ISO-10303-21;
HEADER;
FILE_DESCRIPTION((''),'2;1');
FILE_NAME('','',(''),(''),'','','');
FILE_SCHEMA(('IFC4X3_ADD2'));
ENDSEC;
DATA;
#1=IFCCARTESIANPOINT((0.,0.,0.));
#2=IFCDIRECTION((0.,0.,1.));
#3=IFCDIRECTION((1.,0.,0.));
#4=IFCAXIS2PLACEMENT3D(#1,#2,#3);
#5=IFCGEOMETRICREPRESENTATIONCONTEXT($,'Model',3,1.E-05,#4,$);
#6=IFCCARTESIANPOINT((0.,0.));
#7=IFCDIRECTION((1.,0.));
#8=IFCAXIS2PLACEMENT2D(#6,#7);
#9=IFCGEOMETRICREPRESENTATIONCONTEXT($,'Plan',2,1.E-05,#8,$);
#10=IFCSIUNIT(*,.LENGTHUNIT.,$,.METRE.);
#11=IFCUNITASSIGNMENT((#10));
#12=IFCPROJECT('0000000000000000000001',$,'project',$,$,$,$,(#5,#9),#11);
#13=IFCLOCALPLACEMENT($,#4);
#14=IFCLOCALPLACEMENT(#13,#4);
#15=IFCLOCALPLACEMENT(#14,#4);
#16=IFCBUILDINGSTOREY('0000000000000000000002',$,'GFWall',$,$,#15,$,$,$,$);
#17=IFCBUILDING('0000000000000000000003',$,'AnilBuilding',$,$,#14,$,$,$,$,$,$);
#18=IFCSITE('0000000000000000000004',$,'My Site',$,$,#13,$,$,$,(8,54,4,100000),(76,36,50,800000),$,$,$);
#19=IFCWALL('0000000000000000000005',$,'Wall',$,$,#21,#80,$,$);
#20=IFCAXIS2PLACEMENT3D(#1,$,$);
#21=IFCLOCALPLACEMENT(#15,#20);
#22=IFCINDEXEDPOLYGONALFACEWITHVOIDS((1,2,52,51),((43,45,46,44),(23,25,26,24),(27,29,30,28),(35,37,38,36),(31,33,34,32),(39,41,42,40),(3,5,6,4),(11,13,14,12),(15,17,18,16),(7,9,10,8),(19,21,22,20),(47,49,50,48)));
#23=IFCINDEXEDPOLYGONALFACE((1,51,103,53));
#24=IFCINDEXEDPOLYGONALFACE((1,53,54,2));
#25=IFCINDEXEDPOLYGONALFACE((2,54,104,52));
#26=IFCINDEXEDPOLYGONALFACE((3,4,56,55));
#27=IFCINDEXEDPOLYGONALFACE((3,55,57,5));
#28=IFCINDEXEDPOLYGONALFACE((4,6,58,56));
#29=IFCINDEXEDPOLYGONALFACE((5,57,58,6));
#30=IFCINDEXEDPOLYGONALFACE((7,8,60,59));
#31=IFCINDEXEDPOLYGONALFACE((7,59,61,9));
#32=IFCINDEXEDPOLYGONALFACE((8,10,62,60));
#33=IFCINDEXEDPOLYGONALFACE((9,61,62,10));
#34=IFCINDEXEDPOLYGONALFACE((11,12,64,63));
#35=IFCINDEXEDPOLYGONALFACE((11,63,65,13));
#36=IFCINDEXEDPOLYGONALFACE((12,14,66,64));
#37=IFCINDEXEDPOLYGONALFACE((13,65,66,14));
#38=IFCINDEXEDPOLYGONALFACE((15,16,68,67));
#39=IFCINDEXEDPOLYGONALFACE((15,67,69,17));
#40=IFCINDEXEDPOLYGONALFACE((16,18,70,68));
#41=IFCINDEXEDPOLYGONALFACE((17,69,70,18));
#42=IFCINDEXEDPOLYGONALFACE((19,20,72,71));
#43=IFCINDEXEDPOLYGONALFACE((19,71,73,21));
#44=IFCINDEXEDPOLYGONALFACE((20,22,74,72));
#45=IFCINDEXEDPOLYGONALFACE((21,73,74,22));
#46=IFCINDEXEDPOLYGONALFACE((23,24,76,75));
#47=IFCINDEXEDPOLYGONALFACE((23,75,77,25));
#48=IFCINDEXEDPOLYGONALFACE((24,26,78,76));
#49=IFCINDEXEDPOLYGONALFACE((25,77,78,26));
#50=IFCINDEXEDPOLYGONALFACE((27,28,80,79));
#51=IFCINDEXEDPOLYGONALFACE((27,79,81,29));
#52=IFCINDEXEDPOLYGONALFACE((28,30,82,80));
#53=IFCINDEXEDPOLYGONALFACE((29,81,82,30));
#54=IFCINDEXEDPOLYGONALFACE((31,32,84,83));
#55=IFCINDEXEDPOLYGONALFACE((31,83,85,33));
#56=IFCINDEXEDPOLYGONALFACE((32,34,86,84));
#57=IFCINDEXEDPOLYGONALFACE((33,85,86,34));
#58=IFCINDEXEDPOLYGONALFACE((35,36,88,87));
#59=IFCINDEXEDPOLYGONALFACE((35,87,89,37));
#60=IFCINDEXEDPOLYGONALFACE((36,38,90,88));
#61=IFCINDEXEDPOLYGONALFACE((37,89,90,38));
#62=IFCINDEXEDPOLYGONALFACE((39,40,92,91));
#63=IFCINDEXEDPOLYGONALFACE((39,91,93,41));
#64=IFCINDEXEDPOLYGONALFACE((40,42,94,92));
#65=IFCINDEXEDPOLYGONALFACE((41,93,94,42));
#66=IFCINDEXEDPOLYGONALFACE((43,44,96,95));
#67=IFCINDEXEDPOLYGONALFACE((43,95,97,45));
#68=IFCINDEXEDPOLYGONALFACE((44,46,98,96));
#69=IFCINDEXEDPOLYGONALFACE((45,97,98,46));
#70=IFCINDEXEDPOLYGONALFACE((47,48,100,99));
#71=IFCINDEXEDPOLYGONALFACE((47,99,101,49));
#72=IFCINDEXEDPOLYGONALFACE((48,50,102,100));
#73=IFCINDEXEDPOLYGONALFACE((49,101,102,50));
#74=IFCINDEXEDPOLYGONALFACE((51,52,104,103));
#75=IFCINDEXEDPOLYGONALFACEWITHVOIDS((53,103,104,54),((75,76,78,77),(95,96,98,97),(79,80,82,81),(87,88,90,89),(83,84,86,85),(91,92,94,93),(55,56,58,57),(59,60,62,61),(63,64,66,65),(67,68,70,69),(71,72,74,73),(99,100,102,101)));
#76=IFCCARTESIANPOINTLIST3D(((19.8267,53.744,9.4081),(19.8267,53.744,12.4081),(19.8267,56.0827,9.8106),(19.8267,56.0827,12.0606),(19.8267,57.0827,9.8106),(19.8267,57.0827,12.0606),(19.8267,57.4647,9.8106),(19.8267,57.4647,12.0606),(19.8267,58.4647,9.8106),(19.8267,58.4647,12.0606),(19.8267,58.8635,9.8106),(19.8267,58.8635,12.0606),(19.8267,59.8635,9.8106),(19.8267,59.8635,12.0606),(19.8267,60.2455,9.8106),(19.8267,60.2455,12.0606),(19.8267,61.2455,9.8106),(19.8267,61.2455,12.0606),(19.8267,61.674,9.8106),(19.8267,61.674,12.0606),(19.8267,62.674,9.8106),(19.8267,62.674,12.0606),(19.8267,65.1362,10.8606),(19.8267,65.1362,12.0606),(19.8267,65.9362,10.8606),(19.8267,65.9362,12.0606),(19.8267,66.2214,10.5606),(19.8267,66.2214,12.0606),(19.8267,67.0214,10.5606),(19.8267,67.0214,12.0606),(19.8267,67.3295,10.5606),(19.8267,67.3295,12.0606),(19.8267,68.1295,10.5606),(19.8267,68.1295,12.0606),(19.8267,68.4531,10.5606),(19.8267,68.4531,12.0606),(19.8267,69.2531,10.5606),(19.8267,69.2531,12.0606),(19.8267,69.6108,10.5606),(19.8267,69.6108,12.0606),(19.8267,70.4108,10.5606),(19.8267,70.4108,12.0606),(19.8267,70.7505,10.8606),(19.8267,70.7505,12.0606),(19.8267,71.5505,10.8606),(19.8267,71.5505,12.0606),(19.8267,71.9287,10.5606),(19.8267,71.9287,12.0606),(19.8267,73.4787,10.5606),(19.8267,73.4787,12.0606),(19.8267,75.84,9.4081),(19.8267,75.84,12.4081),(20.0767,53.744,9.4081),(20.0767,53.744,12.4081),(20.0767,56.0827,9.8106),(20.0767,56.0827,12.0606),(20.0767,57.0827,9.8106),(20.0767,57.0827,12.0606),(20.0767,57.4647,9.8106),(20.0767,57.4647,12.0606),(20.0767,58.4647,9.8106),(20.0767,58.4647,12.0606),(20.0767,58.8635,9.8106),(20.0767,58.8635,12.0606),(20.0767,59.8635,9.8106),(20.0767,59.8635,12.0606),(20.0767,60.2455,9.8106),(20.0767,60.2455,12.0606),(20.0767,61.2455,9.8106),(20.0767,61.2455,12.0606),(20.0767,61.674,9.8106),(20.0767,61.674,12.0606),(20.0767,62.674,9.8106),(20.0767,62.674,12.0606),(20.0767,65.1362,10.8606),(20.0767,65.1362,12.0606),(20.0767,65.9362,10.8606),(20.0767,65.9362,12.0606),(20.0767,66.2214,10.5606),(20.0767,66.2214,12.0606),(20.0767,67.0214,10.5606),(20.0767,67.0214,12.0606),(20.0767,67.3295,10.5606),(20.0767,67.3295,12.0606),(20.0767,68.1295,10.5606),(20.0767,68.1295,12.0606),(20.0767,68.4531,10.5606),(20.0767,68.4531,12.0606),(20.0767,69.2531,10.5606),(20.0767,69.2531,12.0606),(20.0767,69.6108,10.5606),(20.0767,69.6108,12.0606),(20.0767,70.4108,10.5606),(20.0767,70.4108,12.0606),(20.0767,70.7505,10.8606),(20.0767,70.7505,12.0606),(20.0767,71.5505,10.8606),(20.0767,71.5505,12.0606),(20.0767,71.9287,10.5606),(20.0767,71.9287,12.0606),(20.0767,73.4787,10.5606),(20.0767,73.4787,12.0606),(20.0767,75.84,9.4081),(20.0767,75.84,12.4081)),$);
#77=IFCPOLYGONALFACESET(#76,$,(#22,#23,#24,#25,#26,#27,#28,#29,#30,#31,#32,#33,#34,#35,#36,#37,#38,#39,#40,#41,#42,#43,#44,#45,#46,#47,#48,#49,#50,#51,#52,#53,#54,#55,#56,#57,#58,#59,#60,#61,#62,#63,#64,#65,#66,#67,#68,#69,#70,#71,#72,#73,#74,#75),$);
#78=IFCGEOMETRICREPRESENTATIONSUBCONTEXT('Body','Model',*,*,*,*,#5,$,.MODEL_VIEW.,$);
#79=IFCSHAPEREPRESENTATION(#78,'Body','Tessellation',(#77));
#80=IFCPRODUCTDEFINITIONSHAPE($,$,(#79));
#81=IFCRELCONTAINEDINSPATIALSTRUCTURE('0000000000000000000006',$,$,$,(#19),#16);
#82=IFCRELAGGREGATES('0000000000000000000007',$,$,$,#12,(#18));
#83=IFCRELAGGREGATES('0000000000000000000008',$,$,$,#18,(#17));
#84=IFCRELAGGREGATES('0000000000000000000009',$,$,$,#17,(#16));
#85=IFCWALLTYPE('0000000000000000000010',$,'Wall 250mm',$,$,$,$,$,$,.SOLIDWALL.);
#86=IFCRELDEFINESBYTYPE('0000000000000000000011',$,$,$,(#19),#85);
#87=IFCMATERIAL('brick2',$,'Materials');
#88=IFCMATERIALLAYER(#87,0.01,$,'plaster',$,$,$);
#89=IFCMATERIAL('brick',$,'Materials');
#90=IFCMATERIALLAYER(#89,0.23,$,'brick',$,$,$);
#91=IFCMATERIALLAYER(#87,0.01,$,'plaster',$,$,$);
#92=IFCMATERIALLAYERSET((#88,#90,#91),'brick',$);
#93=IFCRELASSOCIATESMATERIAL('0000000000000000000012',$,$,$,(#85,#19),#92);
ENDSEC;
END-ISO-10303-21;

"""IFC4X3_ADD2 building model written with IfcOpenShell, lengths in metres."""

from ifc_helpers import new_model, si_unit, frame, origin_with_axes, origin_2d_with_axis, place, context, subcontext, project, spatial, line, indexed_curve, outline, extrude, source, transform, mapped, material, layer, layer_set, layer_usage, type_object, element, save


model = new_model("IFC4X3_ADD2")

# Units and contexts
model_context = context("Model", 3, precision=1e-05, world=origin_with_axes())
plan_context = context("Plan", 2, precision=1e-05, world=origin_2d_with_axis())
body_context = subcontext(model_context, "Body", "Model", "MODEL_VIEW")
ifc_project = project(units=[si_unit("LENGTHUNIT", "METRE")], contexts=[model_context, plan_context])

# Site, building, storey
site_placement = place(None, origin_with_axes())
site = spatial("IfcSite", under=ifc_project, at=site_placement, Name="My Site", RefLatitude=(8, 54, 4, 100000), RefLongitude=(76, 36, 50, 800000))
building_placement = place(site_placement, origin_with_axes())
building = spatial("IfcBuilding", under=site, at=building_placement, Name="AnilBuilding")
storey_placement = place(building_placement, origin_with_axes())
storey = spatial("IfcBuildingStorey", under=building, at=storey_placement, Name="GFWall")

# Wall, openings
ifc_material_1 = material(Name="brick2", Category="Materials")
ifc_layer_1 = layer(ifc_material_1, 0.01, Name="plaster")
ifc_material_2 = material(Name="brick", Category="Materials")
ifc_layer_2 = layer(ifc_material_2, 0.23, Name="brick")
ifc_layer_3 = layer(ifc_material_1, 0.01, Name="plaster")
ifc_layer_set = layer_set([ifc_layer_1, ifc_layer_2, ifc_layer_3], Name="brick")
ifc_layer_usage = layer_usage(ifc_layer_set, "AXIS2", "POSITIVE", 0.0)
wall_type = type_object("IfcWallType", Name="Wall 250mm", PredefinedType="SOLIDWALL", material=ifc_layer_set)
wall_placement = place(storey_placement, frame((20.0767, 53.744, 9.4081), z_axis=(0.0, 0.0, 1.0), x_axis=(0.0, 1.0, 0.0)))
wall = element("IfcWall", 1, at=wall_placement, inside=storey, type_object=wall_type, material=ifc_layer_usage, Name="Wall", context=body_context, shape_type="SweptSolid", body=[
    extrude(outline(indexed_curve([(0.0, 0.0), (0.0, 0.25), (22.096, 0.25), (22.096, 0.0)], segments=[line(1, 2, 3, 4, 1)])), origin_with_axes(), (0.0, 0.0, 1.0), 3.0),
])
shared_shape_1 = source(origin_with_axes(), body_context, "Body", "SweptSolid", [
    extrude(outline(indexed_curve([(0.0, 0.0), (1.0, 0.0), (1.0, 2.25), (0.0, 2.25)], segments=[line(1, 2, 3, 4, 1)])), frame((0.0, -0.6, 0.0), z_axis=(0.0, -1.0, 0.0), x_axis=(1.0, 0.0, 0.0)), (0.0, 0.0, -1.0), 1.2),
])
opening_1_placement = place(wall_placement, frame((2.3387, 0.0, 0.4025), z_axis=(0.0, 0.0, 1.0), x_axis=(1.0, 0.0, 0.0)))
element("IfcOpeningElement", 2, at=opening_1_placement, cuts=wall, PredefinedType="OPENING", context=body_context, shape_type="MappedRepresentation", body=[
    mapped(shared_shape_1, transform((0.0, 0.0, 0.0), x_axis=(1.0, 0.0, 0.0), y_axis=(0.0, 1.0, 0.0), z_axis=(0.0, 0.0, 1.0), scale=1.0)),
])
opening_2_placement = place(wall_placement, frame((3.7207, 0.0, 0.4025), z_axis=(0.0, 0.0, 1.0), x_axis=(1.0, 0.0, 0.0)))
element("IfcOpeningElement", 3, at=opening_2_placement, cuts=wall, PredefinedType="OPENING", context=body_context, shape_type="MappedRepresentation", body=[
    mapped(shared_shape_1, transform((0.0, 0.0, 0.0), x_axis=(1.0, 0.0, 0.0), y_axis=(0.0, 1.0, 0.0), z_axis=(0.0, 0.0, 1.0), scale=1.0)),
])
opening_3_placement = place(wall_placement, frame((5.1195, 0.0, 0.4025), z_axis=(0.0, 0.0, 1.0), x_axis=(1.0, 0.0, 0.0)))
element("IfcOpeningElement", 4, at=opening_3_placement, cuts=wall, PredefinedType="OPENING", context=body_context, shape_type="MappedRepresentation", body=[
    mapped(shared_shape_1, transform((0.0, 0.0, 0.0), x_axis=(1.0, 0.0, 0.0), y_axis=(0.0, 1.0, 0.0), z_axis=(0.0, 0.0, 1.0), scale=1.0)),
])
opening_4_placement = place(wall_placement, frame((6.5014, 0.0, 0.4025), z_axis=(0.0, 0.0, 1.0), x_axis=(1.0, 0.0, 0.0)))
element("IfcOpeningElement", 5, at=opening_4_placement, cuts=wall, PredefinedType="OPENING", context=body_context, shape_type="MappedRepresentation", body=[
    mapped(shared_shape_1, transform((0.0, 0.0, 0.0), x_axis=(1.0, 0.0, 0.0), y_axis=(0.0, 1.0, 0.0), z_axis=(0.0, 0.0, 1.0), scale=1.0)),
])
opening_5_placement = place(wall_placement, frame((7.93, 0.0, 0.4025), z_axis=(0.0, 0.0, 1.0), x_axis=(1.0, 0.0, 0.0)))
element("IfcOpeningElement", 6, at=opening_5_placement, cuts=wall, PredefinedType="OPENING", context=body_context, shape_type="MappedRepresentation", body=[
    mapped(shared_shape_1, transform((0.0, 0.0, 0.0), x_axis=(1.0, 0.0, 0.0), y_axis=(0.0, 1.0, 0.0), z_axis=(0.0, 0.0, 1.0), scale=1.0)),
])
shared_shape_2 = source(origin_with_axes(), body_context, "Body", "SweptSolid", [
    extrude(outline(indexed_curve([(0.0, 0.0), (1.55, 0.0), (1.55, 1.5), (0.0, 1.5)], segments=[line(1, 2, 3, 4, 1)])), frame((0.0, -0.6, 0.0), z_axis=(0.0, -1.0, 0.0), x_axis=(1.0, 0.0, 0.0)), (0.0, 0.0, -1.0), 1.2),
])
opening_6_placement = place(wall_placement, frame((18.1847, 0.0, 1.1525), z_axis=(0.0, 0.0, 1.0), x_axis=(1.0, 0.0, 0.0)))
element("IfcOpeningElement", 7, at=opening_6_placement, cuts=wall, PredefinedType="OPENING", context=body_context, shape_type="MappedRepresentation", body=[
    mapped(shared_shape_2, transform((0.0, 0.0, 0.0), x_axis=(1.0, 0.0, 0.0), y_axis=(0.0, 1.0, 0.0), z_axis=(0.0, 0.0, 1.0), scale=1.0)),
])
shared_shape_3 = source(origin_with_axes(), body_context, "Body", "SweptSolid", [
    extrude(outline(indexed_curve([(0.0, 0.0), (0.8, 0.0), (0.8, 1.2), (0.0, 1.2)], segments=[line(1, 2, 3, 4, 1)])), frame((0.0, -0.6, 0.0), z_axis=(0.0, -1.0, 0.0), x_axis=(1.0, 0.0, 0.0)), (0.0, 0.0, -1.0), 1.2),
])
opening_7_placement = place(wall_placement, frame((11.3922, 0.0, 1.4525), z_axis=(0.0, 0.0, 1.0), x_axis=(1.0, 0.0, 0.0)))
element("IfcOpeningElement", 8, at=opening_7_placement, cuts=wall, PredefinedType="OPENING", context=body_context, shape_type="MappedRepresentation", body=[
    mapped(shared_shape_3, transform((0.0, 0.0, 0.0), x_axis=(1.0, 0.0, 0.0), y_axis=(0.0, 1.0, 0.0), z_axis=(0.0, 0.0, 1.0), scale=1.0)),
])
shared_shape_4 = source(origin_with_axes(), body_context, "Body", "SweptSolid", [
    extrude(outline(indexed_curve([(0.0, 0.0), (0.8, 0.0), (0.8, 1.5), (0.0, 1.5)], segments=[line(1, 2, 3, 4, 1)])), frame((0.0, -0.6, 0.0), z_axis=(0.0, -1.0, 0.0), x_axis=(1.0, 0.0, 0.0)), (0.0, 0.0, -1.0), 1.2),
])
opening_8_placement = place(wall_placement, frame((12.4774, 0.0, 1.1525), z_axis=(0.0, 0.0, 1.0), x_axis=(1.0, 0.0, 0.0)))
element("IfcOpeningElement", 9, at=opening_8_placement, cuts=wall, PredefinedType="OPENING", context=body_context, shape_type="MappedRepresentation", body=[
    mapped(shared_shape_4, transform((0.0, 0.0, 0.0), x_axis=(1.0, 0.0, 0.0), y_axis=(0.0, 1.0, 0.0), z_axis=(0.0, 0.0, 1.0), scale=1.0)),
])
shared_shape_5 = source(origin_with_axes(), body_context, "Body", "SweptSolid", [
    extrude(outline(indexed_curve([(0.0, 1.5), (0.8, 1.5), (0.8, 0.0), (0.0, 0.0), (0.0, 1.5)])), frame((0.0, -0.6, 0.0), z_axis=(0.0, -1.0, 0.0), x_axis=(1.0, 0.0, 0.0)), (0.0, 0.0, -1.0), 1.2),
])
opening_9_placement = place(wall_placement, frame((13.5855, 0.0, 1.1525), z_axis=(0.0, 0.0, 1.0), x_axis=(1.0, 0.0, 0.0)))
element("IfcOpeningElement", 10, at=opening_9_placement, cuts=wall, PredefinedType="OPENING", context=body_context, shape_type="MappedRepresentation", body=[
    mapped(shared_shape_5, transform((0.0, 0.0, 0.0), x_axis=(1.0, 0.0, 0.0), y_axis=(0.0, 1.0, 0.0), z_axis=(0.0, 0.0, 1.0), scale=1.0)),
])
opening_10_placement = place(wall_placement, frame((14.7091, 0.0, 1.1525), z_axis=(0.0, 0.0, 1.0), x_axis=(1.0, 0.0, 0.0)))
element("IfcOpeningElement", 11, at=opening_10_placement, cuts=wall, PredefinedType="OPENING", context=body_context, shape_type="MappedRepresentation", body=[
    mapped(shared_shape_4, transform((0.0, 0.0, 0.0), x_axis=(1.0, 0.0, 0.0), y_axis=(0.0, 1.0, 0.0), z_axis=(0.0, 0.0, 1.0), scale=1.0)),
])
opening_11_placement = place(wall_placement, frame((15.8668, 0.0, 1.1525), z_axis=(0.0, 0.0, 1.0), x_axis=(1.0, 0.0, 0.0)))
element("IfcOpeningElement", 12, at=opening_11_placement, cuts=wall, PredefinedType="OPENING", context=body_context, shape_type="MappedRepresentation", body=[
    mapped(shared_shape_5, transform((0.0, 0.0, 0.0), x_axis=(1.0, 0.0, 0.0), y_axis=(0.0, 1.0, 0.0), z_axis=(0.0, 0.0, 1.0), scale=1.0)),
])
opening_12_placement = place(wall_placement, frame((17.0065, 0.0, 1.4525), z_axis=(0.0, 0.0, 1.0), x_axis=(1.0, 0.0, 0.0)))
element("IfcOpeningElement", 13, at=opening_12_placement, cuts=wall, PredefinedType="OPENING", context=body_context, shape_type="MappedRepresentation", body=[
    mapped(shared_shape_3, transform((0.0, 0.0, 0.0), x_axis=(1.0, 0.0, 0.0), y_axis=(0.0, 1.0, 0.0), z_axis=(0.0, 0.0, 1.0), scale=1.0)),
])

save(model, "model.ifc")
